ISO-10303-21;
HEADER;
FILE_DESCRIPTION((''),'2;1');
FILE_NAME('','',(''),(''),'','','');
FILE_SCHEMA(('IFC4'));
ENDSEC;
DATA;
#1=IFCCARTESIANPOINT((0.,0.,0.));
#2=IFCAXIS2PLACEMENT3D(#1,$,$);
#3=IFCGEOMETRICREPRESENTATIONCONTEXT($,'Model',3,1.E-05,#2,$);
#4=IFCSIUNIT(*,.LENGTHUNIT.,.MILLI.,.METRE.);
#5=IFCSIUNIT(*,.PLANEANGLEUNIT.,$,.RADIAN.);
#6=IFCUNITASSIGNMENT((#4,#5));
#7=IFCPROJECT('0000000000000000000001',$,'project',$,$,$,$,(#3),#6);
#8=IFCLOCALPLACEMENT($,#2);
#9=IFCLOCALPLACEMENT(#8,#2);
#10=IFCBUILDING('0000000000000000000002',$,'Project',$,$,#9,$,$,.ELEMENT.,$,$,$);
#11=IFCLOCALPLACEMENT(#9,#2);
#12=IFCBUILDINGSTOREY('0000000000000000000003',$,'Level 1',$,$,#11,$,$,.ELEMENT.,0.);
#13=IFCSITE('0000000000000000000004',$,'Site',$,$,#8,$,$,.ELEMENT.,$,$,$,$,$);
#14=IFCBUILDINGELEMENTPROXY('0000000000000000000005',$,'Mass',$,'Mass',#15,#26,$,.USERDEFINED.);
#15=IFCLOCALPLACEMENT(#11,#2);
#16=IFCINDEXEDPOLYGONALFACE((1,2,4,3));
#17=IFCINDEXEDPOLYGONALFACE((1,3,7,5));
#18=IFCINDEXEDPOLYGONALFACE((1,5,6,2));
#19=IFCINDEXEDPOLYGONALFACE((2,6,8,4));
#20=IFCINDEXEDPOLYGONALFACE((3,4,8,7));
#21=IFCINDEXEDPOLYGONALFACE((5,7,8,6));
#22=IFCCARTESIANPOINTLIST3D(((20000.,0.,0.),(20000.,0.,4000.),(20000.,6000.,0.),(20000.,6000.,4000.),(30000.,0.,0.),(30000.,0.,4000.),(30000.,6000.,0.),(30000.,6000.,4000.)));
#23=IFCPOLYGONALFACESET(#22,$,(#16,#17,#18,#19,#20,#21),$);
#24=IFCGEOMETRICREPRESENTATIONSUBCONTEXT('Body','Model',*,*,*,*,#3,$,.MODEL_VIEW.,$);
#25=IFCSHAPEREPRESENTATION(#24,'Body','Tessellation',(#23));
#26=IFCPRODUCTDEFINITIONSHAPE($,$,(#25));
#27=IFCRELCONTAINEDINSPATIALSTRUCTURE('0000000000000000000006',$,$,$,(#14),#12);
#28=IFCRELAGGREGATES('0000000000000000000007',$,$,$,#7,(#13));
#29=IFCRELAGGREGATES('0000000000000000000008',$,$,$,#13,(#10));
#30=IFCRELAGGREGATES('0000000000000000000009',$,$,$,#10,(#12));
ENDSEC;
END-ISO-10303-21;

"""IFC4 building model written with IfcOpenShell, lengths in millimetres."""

from ifc_helpers import new_model, si_unit, origin, place, context, subcontext, project, spatial, polyline, outline, extrude, element, save


model = new_model("IFC4")

# Units and contexts
model_context = context("Model", 3, precision=1e-05, world=origin())
body_context = subcontext(model_context, "Body", "Model", "MODEL_VIEW")
ifc_project = project(units=[si_unit("LENGTHUNIT", "METRE", prefix="MILLI"), si_unit("PLANEANGLEUNIT", "RADIAN")], contexts=[model_context])

# Site, building, storey
site_placement = place(None, origin())
site = spatial("IfcSite", under=ifc_project, at=site_placement, Name="Site", CompositionType="ELEMENT")
building_placement = place(site_placement, origin())
building = spatial("IfcBuilding", under=site, at=building_placement, Name="Project", CompositionType="ELEMENT")
storey_placement = place(building_placement, origin())
storey = spatial("IfcBuildingStorey", under=building, at=storey_placement, Name="Level 1", CompositionType="ELEMENT", Elevation=0.0)

# Building element proxy
proxy_placement = place(storey_placement, origin())
element("IfcBuildingElementProxy", 1, at=proxy_placement, inside=storey, Name="Mass", ObjectType="Mass", PredefinedType="USERDEFINED", context=body_context, shape_type="SweptSolid", body=[
    extrude(outline(polyline([(20000.0, 0.0), (30000.0, 0.0), (30000.0, 6000.0), (20000.0, 6000.0), (20000.0, 0.0)])), origin(), (0.0, 0.0, 1.0), 4000.0),
])

save(model, "model.ifc")
